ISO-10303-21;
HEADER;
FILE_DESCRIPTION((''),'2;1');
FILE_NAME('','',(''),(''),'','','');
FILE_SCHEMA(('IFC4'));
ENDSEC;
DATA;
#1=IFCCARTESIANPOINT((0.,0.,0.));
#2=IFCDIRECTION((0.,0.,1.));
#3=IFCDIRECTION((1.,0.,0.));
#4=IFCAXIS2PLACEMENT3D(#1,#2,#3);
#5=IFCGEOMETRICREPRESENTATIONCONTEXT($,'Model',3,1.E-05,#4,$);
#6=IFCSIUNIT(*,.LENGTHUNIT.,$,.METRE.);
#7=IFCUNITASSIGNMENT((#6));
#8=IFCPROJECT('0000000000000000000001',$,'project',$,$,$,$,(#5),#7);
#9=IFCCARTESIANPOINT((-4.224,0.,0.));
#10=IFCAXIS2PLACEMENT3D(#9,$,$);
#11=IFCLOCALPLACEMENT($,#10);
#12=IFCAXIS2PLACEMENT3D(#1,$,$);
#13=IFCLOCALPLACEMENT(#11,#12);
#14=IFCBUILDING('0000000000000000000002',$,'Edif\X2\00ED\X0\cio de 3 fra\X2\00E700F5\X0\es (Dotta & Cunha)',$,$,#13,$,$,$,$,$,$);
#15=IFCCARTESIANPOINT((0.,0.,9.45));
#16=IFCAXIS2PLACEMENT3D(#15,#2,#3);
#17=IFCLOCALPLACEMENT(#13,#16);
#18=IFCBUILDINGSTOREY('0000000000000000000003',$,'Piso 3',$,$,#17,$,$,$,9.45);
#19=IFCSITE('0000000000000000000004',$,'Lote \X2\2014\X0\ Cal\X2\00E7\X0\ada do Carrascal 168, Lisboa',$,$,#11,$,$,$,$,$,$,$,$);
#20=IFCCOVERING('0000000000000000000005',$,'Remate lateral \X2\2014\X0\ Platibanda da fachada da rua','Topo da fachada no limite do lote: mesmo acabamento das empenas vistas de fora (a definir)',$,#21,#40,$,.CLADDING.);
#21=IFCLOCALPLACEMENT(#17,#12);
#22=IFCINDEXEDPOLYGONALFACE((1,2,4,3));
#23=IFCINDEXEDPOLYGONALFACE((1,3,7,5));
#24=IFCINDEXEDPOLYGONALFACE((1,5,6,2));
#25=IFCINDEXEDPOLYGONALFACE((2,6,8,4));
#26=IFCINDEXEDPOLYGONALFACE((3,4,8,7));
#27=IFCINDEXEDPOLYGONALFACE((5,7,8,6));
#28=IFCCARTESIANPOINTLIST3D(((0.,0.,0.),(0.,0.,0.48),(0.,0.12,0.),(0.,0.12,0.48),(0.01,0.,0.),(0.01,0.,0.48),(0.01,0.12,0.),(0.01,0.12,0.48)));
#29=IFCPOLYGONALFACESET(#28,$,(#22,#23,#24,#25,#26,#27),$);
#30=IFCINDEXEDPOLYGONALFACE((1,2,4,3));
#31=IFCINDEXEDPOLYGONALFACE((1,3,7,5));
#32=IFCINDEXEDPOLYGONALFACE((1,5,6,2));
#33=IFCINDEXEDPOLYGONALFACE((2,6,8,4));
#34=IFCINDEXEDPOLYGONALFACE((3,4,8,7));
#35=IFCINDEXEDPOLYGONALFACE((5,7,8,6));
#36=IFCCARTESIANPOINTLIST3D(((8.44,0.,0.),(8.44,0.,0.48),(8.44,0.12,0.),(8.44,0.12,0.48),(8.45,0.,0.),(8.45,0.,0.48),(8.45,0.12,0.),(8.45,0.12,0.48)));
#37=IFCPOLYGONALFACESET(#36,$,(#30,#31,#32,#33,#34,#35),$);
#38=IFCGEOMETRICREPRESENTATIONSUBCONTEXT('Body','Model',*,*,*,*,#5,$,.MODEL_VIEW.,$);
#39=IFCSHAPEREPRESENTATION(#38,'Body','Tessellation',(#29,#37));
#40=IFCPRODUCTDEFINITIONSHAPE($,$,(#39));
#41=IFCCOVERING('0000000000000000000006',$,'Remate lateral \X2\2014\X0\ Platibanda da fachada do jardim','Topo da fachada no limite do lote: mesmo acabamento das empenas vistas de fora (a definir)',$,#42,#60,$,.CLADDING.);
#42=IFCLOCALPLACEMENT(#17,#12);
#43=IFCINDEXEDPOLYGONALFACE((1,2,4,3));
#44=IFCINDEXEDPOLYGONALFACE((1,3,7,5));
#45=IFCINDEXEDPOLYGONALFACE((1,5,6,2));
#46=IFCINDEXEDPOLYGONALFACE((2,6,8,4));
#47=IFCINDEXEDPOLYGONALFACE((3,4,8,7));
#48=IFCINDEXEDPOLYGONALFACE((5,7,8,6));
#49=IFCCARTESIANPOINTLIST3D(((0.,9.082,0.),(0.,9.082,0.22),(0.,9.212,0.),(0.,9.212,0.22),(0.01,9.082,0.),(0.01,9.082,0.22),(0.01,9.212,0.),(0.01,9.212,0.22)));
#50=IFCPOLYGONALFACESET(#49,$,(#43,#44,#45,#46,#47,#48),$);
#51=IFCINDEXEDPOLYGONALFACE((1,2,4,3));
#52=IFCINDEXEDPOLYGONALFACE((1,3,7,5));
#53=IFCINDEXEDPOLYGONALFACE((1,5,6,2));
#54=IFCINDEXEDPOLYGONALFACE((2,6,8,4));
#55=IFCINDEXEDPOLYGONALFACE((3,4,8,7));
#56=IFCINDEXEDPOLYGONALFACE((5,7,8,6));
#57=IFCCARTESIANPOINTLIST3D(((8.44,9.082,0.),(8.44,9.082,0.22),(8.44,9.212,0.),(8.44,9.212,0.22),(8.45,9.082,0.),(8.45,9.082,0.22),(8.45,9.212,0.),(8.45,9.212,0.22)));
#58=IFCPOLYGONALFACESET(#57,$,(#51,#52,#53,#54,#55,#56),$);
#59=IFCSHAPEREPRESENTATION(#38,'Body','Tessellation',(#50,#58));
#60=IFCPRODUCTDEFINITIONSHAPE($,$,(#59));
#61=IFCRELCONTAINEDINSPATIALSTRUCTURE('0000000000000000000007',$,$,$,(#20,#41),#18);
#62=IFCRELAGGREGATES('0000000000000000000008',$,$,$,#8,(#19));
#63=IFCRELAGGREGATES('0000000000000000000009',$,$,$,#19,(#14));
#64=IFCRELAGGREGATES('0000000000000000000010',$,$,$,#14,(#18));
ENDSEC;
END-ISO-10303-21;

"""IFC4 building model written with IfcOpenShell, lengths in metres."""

from ifc_helpers import new_model, si_unit, frame, origin, origin_with_axes, place, context, subcontext, project, spatial, line, indexed_curve, outline, extrude, element, save


model = new_model("IFC4")

# Units and contexts
model_context = context("Model", 3, precision=1e-05, world=origin_with_axes())
body_context = subcontext(model_context, "Body", "Model", "MODEL_VIEW")
ifc_project = project(units=[si_unit("LENGTHUNIT", "METRE")], contexts=[model_context])

# Site, building, storey
site_placement = place(None, frame((-4.224, 0.0, 0.0)))
site = spatial("IfcSite", under=ifc_project, at=site_placement, Name="Lote — Calçada do Carrascal 168, Lisboa")
building_placement = place(site_placement, origin())
building = spatial("IfcBuilding", under=site, at=building_placement, Name="Edifício de 3 frações (Dotta & Cunha)")
storey_placement = place(building_placement, frame((0.0, 0.0, 9.45), z_axis=(0.0, 0.0, 1.0), x_axis=(1.0, 0.0, 0.0)))
storey = spatial("IfcBuildingStorey", under=building, at=storey_placement, Name="Piso 3", Elevation=9.45)

# Coverings
covering_1_placement = place(storey_placement, origin_with_axes())
element("IfcCovering", 1, at=covering_1_placement, inside=storey, Name="Remate lateral — Platibanda da fachada da rua", Description="Topo da fachada no limite do lote: mesmo acabamento das empenas vistas de fora (a definir)", PredefinedType="CLADDING", context=body_context, shape_type="SweptSolid", body=[
    extrude(outline(indexed_curve([(0.0, 0.0), (0.0, 0.12), (0.01, 0.12), (0.01, 0.0)], segments=[line(1, 2, 3, 4, 1)])), origin_with_axes(), (0.0, 0.0, 1.0), 0.48),
    extrude(outline(indexed_curve([(8.44, 0.0), (8.44, 0.12), (8.45, 0.12), (8.45, 0.0)], segments=[line(1, 2, 3, 4, 1)])), origin_with_axes(), (0.0, 0.0, 1.0), 0.48),
])
covering_2_placement = place(storey_placement, origin_with_axes())
element("IfcCovering", 2, at=covering_2_placement, inside=storey, Name="Remate lateral — Platibanda da fachada do jardim", Description="Topo da fachada no limite do lote: mesmo acabamento das empenas vistas de fora (a definir)", PredefinedType="CLADDING", context=body_context, shape_type="SweptSolid", body=[
    extrude(outline(indexed_curve([(0.0, 9.082), (0.0, 9.212), (0.01, 9.212), (0.01, 9.082)], segments=[line(1, 2, 3, 4, 1)])), origin_with_axes(), (0.0, 0.0, 1.0), 0.22),
    extrude(outline(indexed_curve([(8.44, 9.082), (8.44, 9.212), (8.45, 9.212), (8.45, 9.082)], segments=[line(1, 2, 3, 4, 1)])), origin_with_axes(), (0.0, 0.0, 1.0), 0.22),
])

save(model, "model.ifc")
